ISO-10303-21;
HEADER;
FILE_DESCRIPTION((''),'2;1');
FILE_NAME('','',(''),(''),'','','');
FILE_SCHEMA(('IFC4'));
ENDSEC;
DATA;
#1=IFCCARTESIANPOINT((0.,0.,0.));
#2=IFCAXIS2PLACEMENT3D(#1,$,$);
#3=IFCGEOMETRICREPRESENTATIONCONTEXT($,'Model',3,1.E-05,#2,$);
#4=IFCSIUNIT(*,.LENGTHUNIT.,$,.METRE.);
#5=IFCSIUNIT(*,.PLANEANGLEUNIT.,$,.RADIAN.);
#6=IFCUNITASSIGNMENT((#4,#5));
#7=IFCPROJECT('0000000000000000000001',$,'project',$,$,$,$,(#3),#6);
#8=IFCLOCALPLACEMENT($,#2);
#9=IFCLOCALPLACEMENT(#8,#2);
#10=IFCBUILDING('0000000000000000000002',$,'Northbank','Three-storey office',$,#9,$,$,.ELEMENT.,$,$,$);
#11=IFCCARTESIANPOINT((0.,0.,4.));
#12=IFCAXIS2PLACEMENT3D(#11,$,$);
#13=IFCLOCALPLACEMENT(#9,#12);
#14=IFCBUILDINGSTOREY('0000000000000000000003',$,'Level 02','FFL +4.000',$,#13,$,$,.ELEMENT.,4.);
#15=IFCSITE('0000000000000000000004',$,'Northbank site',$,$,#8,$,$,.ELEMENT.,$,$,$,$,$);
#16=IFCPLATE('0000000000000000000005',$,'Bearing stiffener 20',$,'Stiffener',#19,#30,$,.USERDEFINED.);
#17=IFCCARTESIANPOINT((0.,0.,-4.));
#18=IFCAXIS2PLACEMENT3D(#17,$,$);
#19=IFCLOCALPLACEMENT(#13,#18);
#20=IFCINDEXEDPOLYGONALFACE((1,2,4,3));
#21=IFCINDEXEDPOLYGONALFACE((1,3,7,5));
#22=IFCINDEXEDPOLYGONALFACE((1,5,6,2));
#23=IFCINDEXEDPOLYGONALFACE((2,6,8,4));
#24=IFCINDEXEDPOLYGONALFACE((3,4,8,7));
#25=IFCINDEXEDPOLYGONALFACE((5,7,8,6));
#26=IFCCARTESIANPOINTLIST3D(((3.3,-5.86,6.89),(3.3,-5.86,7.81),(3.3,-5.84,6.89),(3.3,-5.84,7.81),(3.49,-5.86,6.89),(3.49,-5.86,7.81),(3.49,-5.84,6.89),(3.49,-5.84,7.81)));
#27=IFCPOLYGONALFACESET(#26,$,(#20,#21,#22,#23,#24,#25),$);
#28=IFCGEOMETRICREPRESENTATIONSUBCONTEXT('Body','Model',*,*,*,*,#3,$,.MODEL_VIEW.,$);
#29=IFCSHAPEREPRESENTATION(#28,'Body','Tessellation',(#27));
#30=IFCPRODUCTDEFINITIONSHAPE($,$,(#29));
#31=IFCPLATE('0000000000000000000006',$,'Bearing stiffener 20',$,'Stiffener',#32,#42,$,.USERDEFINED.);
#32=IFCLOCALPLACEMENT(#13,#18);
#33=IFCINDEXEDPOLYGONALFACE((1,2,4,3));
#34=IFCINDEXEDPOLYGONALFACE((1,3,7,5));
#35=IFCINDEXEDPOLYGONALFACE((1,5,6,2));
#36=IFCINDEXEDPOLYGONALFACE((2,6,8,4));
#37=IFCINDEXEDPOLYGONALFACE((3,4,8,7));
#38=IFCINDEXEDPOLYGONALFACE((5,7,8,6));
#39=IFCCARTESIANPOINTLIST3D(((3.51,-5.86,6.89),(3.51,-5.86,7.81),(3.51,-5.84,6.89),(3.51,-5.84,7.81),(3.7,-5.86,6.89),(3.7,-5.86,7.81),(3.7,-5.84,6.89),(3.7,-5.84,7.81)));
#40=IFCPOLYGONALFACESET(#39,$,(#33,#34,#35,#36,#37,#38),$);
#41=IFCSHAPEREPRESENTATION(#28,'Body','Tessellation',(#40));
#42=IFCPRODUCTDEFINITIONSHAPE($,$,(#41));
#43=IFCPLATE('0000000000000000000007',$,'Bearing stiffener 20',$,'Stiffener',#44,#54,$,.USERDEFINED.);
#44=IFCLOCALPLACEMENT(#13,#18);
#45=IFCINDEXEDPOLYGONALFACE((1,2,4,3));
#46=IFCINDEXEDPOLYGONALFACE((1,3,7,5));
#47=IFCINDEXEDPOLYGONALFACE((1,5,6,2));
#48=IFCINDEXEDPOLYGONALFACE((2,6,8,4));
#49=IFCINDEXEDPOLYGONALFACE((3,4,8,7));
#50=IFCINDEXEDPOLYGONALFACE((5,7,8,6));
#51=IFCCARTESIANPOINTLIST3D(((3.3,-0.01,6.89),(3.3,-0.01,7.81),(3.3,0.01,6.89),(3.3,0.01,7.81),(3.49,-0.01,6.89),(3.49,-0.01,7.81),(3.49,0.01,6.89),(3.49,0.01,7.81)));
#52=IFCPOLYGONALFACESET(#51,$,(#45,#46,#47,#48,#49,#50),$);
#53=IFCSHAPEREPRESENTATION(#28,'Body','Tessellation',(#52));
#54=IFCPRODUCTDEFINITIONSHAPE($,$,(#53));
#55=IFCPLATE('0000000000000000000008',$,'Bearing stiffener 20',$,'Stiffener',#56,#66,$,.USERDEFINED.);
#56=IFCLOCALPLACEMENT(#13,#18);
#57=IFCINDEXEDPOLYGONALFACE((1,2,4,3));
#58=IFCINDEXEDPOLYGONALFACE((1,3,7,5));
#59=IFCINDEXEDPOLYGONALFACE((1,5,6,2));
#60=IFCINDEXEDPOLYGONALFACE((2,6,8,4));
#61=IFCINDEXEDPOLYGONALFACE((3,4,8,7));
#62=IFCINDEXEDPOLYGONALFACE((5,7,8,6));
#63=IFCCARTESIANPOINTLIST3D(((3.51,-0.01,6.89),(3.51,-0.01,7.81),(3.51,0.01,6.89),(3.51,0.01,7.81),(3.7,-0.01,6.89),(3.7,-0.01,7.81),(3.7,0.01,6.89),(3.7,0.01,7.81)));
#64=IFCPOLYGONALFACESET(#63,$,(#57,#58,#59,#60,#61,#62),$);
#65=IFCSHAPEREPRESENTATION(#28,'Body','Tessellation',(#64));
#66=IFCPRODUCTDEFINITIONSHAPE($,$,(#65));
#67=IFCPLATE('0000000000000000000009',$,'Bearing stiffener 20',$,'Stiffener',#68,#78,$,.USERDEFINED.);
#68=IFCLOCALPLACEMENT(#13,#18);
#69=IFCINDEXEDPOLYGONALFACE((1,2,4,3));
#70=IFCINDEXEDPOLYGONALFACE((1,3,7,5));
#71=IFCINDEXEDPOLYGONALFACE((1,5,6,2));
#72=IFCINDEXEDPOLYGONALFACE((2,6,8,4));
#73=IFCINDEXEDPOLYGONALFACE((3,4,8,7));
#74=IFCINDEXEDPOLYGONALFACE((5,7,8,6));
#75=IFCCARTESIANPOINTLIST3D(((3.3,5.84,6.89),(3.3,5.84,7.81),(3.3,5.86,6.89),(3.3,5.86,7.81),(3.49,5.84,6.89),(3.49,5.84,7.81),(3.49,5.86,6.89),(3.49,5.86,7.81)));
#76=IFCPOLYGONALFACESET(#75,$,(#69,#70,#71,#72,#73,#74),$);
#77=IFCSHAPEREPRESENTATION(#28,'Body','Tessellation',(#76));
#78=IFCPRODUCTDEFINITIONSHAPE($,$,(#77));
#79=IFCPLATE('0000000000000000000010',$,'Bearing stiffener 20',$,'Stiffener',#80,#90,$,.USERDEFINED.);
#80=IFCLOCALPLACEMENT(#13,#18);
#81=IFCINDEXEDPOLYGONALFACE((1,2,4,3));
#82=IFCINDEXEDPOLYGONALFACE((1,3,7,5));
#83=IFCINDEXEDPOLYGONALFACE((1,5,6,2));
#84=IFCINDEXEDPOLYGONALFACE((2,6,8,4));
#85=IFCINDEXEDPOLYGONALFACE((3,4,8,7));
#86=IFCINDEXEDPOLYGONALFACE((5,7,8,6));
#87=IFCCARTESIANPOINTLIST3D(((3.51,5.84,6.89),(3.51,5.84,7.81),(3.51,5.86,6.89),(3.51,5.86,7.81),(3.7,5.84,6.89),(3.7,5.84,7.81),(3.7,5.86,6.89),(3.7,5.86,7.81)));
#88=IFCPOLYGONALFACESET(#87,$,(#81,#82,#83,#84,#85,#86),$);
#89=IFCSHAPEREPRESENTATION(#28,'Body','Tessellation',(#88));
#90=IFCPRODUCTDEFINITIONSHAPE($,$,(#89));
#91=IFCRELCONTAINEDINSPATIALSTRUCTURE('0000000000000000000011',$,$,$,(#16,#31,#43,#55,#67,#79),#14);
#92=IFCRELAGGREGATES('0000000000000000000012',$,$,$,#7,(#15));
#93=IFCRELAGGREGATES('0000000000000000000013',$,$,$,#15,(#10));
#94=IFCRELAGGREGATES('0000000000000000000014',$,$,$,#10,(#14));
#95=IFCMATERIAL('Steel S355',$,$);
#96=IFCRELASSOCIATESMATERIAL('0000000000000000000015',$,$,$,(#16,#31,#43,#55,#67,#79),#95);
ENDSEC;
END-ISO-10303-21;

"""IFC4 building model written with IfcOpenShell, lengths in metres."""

from ifc_helpers import new_model, si_unit, frame, origin, place, context, subcontext, project, spatial, rectangle, extrude, material, element, save


model = new_model("IFC4")

# Units and contexts
model_context = context("Model", 3, precision=1e-05, world=origin())
body_context = subcontext(model_context, "Body", "Model", "MODEL_VIEW")
ifc_project = project(units=[si_unit("LENGTHUNIT", "METRE"), si_unit("PLANEANGLEUNIT", "RADIAN")], contexts=[model_context])

# Site, building, storey
site_placement = place(None, origin())
site = spatial("IfcSite", under=ifc_project, at=site_placement, Name="Northbank site", CompositionType="ELEMENT")
building_placement = place(site_placement, origin())
building = spatial("IfcBuilding", under=site, at=building_placement, Name="Northbank", Description="Three-storey office", CompositionType="ELEMENT")
storey_placement = place(building_placement, frame((0.0, 0.0, 4.0)))
storey = spatial("IfcBuildingStorey", under=building, at=storey_placement, Name="Level 02", Description="FFL +4.000", CompositionType="ELEMENT", Elevation=4.0)

# Shared definitions
ifc_material_1 = material(Name="Steel S355")

# Plates
plate_1_placement = place(storey_placement, frame((0.0, 0.0, -4.0)))
element("IfcPlate", 1, at=plate_1_placement, inside=storey, material=ifc_material_1, Name="Bearing stiffener 20", ObjectType="Stiffener", PredefinedType="USERDEFINED", context=body_context, shape_type="SweptSolid", body=[
    extrude(rectangle(XDim=0.19, YDim=0.02), frame((3.395, -5.85, 6.89)), (0.0, 0.0, 1.0), 0.92),
])
plate_2_placement = place(storey_placement, frame((0.0, 0.0, -4.0)))
element("IfcPlate", 2, at=plate_2_placement, inside=storey, material=ifc_material_1, Name="Bearing stiffener 20", ObjectType="Stiffener", PredefinedType="USERDEFINED", context=body_context, shape_type="SweptSolid", body=[
    extrude(rectangle(XDim=0.19, YDim=0.02), frame((3.605, -5.85, 6.89)), (0.0, 0.0, 1.0), 0.92),
])
plate_3_placement = place(storey_placement, frame((0.0, 0.0, -4.0)))
element("IfcPlate", 3, at=plate_3_placement, inside=storey, material=ifc_material_1, Name="Bearing stiffener 20", ObjectType="Stiffener", PredefinedType="USERDEFINED", context=body_context, shape_type="SweptSolid", body=[
    extrude(rectangle(XDim=0.19, YDim=0.02), frame((3.395, 0.0, 6.89)), (0.0, 0.0, 1.0), 0.92),
])
plate_4_placement = place(storey_placement, frame((0.0, 0.0, -4.0)))
element("IfcPlate", 4, at=plate_4_placement, inside=storey, material=ifc_material_1, Name="Bearing stiffener 20", ObjectType="Stiffener", PredefinedType="USERDEFINED", context=body_context, shape_type="SweptSolid", body=[
    extrude(rectangle(XDim=0.19, YDim=0.02), frame((3.605, 0.0, 6.89)), (0.0, 0.0, 1.0), 0.92),
])
plate_5_placement = place(storey_placement, frame((0.0, 0.0, -4.0)))
element("IfcPlate", 5, at=plate_5_placement, inside=storey, material=ifc_material_1, Name="Bearing stiffener 20", ObjectType="Stiffener", PredefinedType="USERDEFINED", context=body_context, shape_type="SweptSolid", body=[
    extrude(rectangle(XDim=0.19, YDim=0.02), frame((3.395, 5.85, 6.89)), (0.0, 0.0, 1.0), 0.92),
])
plate_6_placement = place(storey_placement, frame((0.0, 0.0, -4.0)))
element("IfcPlate", 6, at=plate_6_placement, inside=storey, material=ifc_material_1, Name="Bearing stiffener 20", ObjectType="Stiffener", PredefinedType="USERDEFINED", context=body_context, shape_type="SweptSolid", body=[
    extrude(rectangle(XDim=0.19, YDim=0.02), frame((3.605, 5.85, 6.89)), (0.0, 0.0, 1.0), 0.92),
])

save(model, "model.ifc")
